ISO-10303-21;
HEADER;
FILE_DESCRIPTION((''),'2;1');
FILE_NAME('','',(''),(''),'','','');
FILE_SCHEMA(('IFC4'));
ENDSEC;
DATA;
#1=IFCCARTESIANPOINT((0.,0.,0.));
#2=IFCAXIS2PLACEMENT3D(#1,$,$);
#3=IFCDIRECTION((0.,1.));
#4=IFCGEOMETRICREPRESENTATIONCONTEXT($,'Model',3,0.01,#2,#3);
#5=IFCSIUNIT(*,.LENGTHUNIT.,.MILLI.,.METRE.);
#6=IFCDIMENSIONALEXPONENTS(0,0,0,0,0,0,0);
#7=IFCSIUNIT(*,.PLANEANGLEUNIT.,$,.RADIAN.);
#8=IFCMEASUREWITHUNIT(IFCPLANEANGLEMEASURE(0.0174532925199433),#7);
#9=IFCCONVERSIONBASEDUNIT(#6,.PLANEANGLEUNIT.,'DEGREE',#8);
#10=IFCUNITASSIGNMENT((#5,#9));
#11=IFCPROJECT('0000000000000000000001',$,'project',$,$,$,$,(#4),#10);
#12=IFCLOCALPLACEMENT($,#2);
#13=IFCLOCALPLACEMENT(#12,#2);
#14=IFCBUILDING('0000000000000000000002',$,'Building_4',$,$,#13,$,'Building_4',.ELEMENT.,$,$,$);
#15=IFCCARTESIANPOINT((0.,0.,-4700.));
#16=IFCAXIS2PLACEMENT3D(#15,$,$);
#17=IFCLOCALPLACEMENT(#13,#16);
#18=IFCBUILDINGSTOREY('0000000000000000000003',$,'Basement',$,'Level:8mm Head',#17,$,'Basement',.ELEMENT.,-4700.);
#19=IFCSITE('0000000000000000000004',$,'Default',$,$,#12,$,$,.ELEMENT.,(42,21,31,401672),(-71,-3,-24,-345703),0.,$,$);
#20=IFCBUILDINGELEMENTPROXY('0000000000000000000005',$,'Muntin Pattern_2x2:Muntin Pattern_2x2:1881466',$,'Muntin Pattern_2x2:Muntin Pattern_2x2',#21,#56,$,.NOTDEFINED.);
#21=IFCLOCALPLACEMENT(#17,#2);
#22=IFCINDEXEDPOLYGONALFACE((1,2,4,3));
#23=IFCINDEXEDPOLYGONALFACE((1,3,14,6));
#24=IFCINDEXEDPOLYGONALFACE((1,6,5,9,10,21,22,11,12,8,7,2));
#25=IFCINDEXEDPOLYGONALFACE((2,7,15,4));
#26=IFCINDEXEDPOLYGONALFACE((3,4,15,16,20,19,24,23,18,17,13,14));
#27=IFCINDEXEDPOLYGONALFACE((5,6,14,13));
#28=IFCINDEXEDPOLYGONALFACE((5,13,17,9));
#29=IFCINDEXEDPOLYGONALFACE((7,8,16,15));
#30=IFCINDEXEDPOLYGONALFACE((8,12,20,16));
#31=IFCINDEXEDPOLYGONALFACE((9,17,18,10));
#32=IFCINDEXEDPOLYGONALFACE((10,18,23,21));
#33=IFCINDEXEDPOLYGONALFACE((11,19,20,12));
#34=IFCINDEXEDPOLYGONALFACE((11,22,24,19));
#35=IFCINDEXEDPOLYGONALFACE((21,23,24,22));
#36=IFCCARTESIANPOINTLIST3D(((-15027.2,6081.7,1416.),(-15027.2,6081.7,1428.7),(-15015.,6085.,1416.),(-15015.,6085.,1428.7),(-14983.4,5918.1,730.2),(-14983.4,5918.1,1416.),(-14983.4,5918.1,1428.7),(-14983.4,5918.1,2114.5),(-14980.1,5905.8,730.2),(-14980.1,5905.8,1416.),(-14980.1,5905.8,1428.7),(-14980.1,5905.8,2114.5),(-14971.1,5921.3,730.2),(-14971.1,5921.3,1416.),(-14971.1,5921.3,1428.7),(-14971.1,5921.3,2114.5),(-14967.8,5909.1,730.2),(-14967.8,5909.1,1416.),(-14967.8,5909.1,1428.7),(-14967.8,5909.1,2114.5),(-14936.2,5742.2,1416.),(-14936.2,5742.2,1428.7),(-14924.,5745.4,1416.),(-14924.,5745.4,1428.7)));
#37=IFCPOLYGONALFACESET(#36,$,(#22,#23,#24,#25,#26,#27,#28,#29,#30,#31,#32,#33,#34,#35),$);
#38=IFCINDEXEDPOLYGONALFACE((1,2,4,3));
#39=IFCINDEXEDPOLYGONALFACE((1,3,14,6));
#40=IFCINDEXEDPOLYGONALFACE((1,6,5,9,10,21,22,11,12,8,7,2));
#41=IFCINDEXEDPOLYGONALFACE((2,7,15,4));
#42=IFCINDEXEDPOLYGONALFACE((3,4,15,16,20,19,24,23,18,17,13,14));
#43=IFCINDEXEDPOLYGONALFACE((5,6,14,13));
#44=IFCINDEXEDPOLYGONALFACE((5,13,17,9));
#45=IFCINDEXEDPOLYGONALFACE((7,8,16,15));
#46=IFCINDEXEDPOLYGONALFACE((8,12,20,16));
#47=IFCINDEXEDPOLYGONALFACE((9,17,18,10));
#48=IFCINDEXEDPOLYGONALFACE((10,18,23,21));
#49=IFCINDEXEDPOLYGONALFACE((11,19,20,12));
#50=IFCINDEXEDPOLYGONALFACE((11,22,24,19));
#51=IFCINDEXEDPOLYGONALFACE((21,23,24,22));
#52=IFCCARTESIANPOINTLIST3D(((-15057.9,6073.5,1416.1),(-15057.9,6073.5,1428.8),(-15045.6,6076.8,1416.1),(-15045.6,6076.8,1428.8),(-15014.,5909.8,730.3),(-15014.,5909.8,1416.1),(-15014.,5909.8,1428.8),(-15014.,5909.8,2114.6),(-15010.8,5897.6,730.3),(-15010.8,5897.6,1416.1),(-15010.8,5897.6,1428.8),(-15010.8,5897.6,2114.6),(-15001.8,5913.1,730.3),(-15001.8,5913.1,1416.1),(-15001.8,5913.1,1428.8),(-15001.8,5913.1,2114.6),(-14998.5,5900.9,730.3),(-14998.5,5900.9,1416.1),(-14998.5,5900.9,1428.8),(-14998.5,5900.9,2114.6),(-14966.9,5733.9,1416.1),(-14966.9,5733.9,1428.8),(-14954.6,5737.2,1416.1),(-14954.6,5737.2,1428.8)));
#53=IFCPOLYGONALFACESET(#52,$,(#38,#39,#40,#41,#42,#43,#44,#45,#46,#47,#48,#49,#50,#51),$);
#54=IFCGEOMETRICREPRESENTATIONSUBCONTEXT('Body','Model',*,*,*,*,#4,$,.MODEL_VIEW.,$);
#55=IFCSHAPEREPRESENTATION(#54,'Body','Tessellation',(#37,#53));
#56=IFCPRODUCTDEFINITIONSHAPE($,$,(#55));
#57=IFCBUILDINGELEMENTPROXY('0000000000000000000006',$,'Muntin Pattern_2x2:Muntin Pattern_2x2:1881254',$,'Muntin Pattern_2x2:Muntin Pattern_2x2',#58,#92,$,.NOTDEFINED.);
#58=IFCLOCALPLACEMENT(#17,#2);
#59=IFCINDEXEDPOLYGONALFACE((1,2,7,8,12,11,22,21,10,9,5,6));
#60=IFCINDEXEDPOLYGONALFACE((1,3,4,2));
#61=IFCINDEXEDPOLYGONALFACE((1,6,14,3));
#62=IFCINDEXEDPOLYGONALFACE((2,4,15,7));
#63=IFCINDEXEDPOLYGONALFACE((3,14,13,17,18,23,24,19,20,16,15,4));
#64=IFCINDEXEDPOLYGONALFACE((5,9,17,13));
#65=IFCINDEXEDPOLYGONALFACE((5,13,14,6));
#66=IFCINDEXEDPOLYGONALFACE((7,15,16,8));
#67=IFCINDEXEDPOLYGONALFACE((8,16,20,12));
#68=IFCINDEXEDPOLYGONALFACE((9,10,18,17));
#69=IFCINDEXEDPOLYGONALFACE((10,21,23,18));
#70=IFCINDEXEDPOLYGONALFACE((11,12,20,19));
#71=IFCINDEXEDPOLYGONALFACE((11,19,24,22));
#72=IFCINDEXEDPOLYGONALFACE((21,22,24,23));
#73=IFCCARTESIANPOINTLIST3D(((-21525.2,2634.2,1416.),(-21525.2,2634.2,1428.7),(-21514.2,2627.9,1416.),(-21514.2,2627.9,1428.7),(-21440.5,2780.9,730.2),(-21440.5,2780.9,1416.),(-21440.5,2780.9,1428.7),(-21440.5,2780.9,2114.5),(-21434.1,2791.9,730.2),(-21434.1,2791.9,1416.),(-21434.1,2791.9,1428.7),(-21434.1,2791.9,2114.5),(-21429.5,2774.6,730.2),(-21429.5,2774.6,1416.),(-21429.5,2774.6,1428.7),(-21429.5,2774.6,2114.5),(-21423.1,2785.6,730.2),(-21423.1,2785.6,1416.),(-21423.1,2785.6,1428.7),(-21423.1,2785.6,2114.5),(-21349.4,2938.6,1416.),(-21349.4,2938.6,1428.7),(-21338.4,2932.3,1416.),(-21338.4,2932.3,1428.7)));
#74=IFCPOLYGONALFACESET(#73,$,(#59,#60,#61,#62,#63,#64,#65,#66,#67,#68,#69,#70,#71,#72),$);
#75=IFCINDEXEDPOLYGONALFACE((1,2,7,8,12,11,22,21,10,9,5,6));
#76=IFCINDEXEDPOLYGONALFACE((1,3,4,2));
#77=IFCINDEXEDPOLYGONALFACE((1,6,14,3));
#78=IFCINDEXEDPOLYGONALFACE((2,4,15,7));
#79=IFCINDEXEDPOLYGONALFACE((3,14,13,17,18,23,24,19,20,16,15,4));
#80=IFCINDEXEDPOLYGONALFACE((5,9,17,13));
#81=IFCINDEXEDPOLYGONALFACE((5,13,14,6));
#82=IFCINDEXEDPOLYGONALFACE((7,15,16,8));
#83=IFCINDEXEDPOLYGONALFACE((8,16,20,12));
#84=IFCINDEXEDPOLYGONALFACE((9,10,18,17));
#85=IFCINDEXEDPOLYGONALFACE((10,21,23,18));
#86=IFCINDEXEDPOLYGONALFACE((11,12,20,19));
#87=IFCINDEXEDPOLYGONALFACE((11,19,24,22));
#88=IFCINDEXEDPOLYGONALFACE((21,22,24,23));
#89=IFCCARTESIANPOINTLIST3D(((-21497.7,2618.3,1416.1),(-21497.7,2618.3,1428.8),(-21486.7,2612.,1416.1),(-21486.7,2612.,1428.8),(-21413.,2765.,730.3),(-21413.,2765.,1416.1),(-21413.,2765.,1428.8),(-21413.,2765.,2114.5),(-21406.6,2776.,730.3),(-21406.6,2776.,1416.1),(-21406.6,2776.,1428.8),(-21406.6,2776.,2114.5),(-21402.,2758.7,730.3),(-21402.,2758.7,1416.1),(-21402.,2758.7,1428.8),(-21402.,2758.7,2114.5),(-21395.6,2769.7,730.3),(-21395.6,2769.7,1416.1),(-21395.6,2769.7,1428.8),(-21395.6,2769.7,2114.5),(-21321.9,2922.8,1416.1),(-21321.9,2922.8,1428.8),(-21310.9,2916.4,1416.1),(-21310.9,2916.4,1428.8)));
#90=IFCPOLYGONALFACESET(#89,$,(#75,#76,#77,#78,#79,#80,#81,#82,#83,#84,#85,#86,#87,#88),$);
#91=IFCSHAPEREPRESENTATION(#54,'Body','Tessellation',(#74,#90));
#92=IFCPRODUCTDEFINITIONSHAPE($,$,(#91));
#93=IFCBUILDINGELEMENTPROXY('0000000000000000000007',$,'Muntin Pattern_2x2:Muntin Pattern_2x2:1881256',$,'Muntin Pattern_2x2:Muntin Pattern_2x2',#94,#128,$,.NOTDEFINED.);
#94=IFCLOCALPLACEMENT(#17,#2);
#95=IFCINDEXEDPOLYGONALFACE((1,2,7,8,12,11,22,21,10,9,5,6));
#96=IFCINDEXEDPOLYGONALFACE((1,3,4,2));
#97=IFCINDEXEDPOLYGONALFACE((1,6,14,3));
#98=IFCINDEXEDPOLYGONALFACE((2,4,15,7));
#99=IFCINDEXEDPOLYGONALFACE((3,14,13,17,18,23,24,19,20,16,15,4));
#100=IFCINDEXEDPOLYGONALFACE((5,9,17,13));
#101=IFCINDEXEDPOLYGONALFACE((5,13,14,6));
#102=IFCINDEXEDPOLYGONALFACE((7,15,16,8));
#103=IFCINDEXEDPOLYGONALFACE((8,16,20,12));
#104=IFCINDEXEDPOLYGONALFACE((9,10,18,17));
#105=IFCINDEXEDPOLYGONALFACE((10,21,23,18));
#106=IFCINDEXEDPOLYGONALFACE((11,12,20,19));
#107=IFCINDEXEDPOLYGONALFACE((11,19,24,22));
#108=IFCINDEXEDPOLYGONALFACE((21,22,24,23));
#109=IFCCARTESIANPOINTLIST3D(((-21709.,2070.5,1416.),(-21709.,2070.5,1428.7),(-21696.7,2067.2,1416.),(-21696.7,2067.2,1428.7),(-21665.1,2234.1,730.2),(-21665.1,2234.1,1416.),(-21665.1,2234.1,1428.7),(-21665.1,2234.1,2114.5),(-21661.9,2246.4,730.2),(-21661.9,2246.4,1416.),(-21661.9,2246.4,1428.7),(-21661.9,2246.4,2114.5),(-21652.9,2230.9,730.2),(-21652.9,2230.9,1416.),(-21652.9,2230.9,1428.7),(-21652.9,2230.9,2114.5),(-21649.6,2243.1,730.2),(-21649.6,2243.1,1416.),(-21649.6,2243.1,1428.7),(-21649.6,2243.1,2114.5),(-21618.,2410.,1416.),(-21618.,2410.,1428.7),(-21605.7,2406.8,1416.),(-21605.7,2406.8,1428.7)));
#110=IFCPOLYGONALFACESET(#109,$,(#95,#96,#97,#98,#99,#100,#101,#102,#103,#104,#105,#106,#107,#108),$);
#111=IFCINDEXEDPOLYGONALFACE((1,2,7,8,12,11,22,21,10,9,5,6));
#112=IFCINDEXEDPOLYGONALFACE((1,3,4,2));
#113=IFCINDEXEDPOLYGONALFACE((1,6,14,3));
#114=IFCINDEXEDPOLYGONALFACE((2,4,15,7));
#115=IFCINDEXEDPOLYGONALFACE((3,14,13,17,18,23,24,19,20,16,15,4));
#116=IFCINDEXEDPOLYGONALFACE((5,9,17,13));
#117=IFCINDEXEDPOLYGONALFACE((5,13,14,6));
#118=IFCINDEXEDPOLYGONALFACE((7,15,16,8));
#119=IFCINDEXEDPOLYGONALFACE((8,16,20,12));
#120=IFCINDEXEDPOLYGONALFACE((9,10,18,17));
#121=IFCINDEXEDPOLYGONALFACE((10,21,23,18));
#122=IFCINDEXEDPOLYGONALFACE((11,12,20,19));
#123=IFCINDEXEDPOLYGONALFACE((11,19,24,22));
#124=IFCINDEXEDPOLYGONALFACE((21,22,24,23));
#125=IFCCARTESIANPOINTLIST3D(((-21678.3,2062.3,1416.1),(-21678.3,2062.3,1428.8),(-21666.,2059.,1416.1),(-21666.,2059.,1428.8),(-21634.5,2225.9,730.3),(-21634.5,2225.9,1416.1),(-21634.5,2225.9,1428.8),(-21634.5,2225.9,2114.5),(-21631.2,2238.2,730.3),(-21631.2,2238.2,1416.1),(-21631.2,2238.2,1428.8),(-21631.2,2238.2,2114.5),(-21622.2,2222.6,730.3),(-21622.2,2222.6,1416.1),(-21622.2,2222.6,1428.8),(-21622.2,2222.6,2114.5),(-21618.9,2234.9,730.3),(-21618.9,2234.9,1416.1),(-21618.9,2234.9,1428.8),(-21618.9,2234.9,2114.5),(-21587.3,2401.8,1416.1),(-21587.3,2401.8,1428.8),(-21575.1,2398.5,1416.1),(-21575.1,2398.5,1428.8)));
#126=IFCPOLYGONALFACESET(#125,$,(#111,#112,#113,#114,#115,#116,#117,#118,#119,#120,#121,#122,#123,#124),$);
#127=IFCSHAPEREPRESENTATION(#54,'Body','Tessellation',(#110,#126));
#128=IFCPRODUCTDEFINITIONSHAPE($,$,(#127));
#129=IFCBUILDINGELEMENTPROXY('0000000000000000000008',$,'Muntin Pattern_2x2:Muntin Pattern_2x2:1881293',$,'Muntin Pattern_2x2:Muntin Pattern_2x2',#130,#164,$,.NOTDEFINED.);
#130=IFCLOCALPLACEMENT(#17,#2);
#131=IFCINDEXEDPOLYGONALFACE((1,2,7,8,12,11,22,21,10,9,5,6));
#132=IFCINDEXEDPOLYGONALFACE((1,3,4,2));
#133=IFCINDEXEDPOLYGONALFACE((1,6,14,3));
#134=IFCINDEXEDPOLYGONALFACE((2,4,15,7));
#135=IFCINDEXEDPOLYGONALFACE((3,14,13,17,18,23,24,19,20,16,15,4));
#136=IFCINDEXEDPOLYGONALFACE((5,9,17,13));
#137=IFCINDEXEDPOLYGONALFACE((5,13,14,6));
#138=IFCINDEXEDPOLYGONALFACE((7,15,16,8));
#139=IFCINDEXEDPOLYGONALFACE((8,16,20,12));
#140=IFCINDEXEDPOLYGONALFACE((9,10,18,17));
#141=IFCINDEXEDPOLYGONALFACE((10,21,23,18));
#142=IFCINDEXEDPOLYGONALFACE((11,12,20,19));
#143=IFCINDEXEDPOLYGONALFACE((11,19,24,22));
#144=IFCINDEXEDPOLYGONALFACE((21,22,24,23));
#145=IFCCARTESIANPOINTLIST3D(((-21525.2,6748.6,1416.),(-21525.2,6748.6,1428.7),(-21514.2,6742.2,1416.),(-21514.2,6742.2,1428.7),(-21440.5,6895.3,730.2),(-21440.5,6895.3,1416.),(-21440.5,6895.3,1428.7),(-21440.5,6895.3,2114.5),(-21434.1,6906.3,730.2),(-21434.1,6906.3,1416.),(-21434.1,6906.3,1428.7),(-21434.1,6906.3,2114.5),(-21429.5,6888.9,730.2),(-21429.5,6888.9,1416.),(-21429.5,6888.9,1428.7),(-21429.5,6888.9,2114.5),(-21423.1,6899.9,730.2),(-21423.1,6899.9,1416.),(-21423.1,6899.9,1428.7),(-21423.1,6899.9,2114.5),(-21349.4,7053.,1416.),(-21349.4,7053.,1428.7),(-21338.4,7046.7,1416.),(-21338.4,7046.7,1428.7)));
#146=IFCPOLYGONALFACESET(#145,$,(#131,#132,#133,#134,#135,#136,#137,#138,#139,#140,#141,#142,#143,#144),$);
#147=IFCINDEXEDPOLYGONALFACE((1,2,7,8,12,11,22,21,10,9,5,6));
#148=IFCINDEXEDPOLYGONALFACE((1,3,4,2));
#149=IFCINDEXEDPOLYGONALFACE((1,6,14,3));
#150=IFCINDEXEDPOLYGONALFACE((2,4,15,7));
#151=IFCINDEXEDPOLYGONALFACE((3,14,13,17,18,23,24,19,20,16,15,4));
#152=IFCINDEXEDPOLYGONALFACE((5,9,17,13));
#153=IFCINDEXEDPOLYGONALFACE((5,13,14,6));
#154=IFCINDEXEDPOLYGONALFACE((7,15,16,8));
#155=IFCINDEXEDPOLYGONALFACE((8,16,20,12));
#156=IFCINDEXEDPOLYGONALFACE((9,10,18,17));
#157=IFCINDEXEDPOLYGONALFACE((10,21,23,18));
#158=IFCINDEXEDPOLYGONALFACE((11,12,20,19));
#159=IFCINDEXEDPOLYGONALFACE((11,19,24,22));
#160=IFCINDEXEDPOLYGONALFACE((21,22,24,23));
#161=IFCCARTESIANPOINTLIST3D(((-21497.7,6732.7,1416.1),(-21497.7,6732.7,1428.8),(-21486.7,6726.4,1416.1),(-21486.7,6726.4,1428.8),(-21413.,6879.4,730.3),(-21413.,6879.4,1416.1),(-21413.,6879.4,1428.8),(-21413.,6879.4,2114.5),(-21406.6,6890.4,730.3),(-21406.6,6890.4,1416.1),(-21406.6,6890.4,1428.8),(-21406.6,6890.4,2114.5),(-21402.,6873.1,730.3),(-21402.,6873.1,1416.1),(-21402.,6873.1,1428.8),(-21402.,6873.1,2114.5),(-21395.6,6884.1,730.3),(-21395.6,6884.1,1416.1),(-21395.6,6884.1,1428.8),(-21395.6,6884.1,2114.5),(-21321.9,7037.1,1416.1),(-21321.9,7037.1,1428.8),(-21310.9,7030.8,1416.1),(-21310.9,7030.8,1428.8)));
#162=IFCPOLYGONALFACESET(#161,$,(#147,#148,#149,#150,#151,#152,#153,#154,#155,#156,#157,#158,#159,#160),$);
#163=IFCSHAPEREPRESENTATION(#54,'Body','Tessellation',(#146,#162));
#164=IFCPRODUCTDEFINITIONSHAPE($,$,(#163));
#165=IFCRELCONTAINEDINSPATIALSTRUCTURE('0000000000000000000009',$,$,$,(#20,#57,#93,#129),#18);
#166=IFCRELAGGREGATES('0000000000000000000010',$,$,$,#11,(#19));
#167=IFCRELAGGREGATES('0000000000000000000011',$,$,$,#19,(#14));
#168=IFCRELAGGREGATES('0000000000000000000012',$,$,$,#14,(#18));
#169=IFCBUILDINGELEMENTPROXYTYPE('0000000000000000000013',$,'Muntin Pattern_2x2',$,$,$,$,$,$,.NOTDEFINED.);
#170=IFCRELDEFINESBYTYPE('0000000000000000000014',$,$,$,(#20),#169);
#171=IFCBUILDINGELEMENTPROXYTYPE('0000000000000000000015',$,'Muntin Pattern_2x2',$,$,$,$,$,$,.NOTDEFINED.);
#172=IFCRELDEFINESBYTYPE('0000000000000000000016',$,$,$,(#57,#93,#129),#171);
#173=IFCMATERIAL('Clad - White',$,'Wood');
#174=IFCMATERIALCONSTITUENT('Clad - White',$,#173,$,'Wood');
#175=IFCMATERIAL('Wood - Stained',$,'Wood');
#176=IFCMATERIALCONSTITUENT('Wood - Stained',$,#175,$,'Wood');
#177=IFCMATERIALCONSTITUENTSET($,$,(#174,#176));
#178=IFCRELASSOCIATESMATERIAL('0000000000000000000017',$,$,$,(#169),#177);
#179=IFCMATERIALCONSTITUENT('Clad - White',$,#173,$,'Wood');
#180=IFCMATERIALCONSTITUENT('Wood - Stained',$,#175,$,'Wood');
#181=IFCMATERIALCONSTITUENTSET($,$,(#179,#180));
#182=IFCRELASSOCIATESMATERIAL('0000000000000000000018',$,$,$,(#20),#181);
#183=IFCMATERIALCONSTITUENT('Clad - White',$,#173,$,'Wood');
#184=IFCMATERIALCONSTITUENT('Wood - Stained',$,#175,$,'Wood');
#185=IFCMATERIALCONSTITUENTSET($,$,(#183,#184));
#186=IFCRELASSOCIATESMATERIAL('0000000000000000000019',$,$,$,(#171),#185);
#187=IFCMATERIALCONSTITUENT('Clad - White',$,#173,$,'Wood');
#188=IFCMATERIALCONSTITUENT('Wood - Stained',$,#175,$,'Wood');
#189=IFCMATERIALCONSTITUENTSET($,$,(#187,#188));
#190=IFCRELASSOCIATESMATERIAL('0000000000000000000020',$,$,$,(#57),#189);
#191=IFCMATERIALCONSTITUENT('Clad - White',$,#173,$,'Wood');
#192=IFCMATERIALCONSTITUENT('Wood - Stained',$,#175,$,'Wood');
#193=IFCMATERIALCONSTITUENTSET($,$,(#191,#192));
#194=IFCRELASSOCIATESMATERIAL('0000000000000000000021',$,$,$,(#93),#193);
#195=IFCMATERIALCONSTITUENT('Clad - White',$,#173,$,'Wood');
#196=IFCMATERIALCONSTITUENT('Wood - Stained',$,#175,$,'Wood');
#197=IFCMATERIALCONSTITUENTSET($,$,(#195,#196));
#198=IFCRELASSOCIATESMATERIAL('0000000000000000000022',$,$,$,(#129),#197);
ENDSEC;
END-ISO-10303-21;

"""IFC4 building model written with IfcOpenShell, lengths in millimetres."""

from ifc_helpers import new_model, entity, si_unit, converted_unit, direction, frame, origin, place, context, subcontext, project, spatial, indexed_curve, outline, extrude, source, transform, mapped, material, constituent, constituent_set, type_object, type_shapes, element, save


model = new_model("IFC4")

# Units and contexts
model_context = context("Model", 3, precision=0.01, world=origin(), true_north=direction((0.0, 1.0)))
body_context = subcontext(model_context, "Body", "Model", "MODEL_VIEW")
ifc_project = project(units=[si_unit("LENGTHUNIT", "METRE", prefix="MILLI"), converted_unit("PLANEANGLEUNIT", "DEGREE", entity("IfcPlaneAngleMeasure", 0.0174532925199433), si_unit("PLANEANGLEUNIT", "RADIAN"), dimensions=[0, 0, 0, 0, 0, 0, 0])], contexts=[model_context])

# Site, building, storey
site_placement = place(None, origin())
site = spatial("IfcSite", under=ifc_project, at=site_placement, Name="Default", CompositionType="ELEMENT", RefLatitude=(42, 21, 31, 401672), RefLongitude=(-71, -3, -24, -345703), RefElevation=0.0)
building_placement = place(site_placement, origin())
building = spatial("IfcBuilding", under=site, at=building_placement, Name="Building_4", LongName="Building_4", CompositionType="ELEMENT")
storey_placement = place(building_placement, frame((0.0, 0.0, -4700.0)))
storey = spatial("IfcBuildingStorey", under=building, at=storey_placement, Name="Basement", ObjectType="Level:8mm Head", LongName="Basement", CompositionType="ELEMENT", Elevation=-4700.0)

# Building element proxies
ifc_material_1 = material(Name="Clad - White", Category="Wood")
ifc_material_2 = material(Name="Wood - Stained", Category="Wood")
ifc_constituent_1 = constituent(ifc_material_1, Name="Clad - White", Category="Wood")
ifc_constituent_2 = constituent(ifc_material_2, Name="Wood - Stained", Category="Wood")
ifc_constituent_set_1 = constituent_set(constituents=[ifc_constituent_1, ifc_constituent_2])
building_element_proxy_type_1 = type_object("IfcBuildingElementProxyType", Name="Muntin Pattern_2x2", PredefinedType="NOTDEFINED", material=ifc_constituent_set_1)
shared_shape_1 = source(origin(), body_context, "Body", "SweptSolid", [
    extrude(outline(indexed_curve([(6.4, -6.4), (692.1, -6.4), (692.1, 6.3), (6.4, 6.3), (6.4, 175.8), (-6.3, 175.8), (-6.3, 6.3), (-692.2, 6.3), (-692.2, -6.4), (-6.3, -6.4), (-6.3, -175.8), (6.4, -175.8), (6.4, -6.4)], self_intersect=False)), frame((0.0, 9.5, 692.1), z_axis=(0.0, 1.0, 0.0), x_axis=(0.0, 0.0, 1.0)), (0.0, 0.0, 1.0), 12.7),
    extrude(outline(indexed_curve([(6.4, -6.4), (692.1, -6.4), (692.1, 6.3), (6.4, 6.3), (6.4, 175.8), (-6.3, 175.8), (-6.3, 6.3), (-692.2, 6.3), (-692.2, -6.4), (-6.3, -6.4), (-6.3, -175.8), (6.4, -175.8), (6.4, -6.4)], self_intersect=False)), frame((0.0, -22.2, 692.2), z_axis=(0.0, 1.0, 0.0), x_axis=(0.0, 0.0, 1.0)), (0.0, 0.0, 1.0), 12.7),
])
type_shapes(building_element_proxy_type_1, [shared_shape_1])
ifc_constituent_3 = constituent(ifc_material_1, Name="Clad - White", Category="Wood")
ifc_constituent_4 = constituent(ifc_material_2, Name="Wood - Stained", Category="Wood")
ifc_constituent_set_2 = constituent_set(constituents=[ifc_constituent_3, ifc_constituent_4])
proxy_1_placement = place(storey_placement, frame((-14990.9, 5909.5, 730.3), z_axis=(0.0, 0.0, 1.0), x_axis=(0.258819, -0.965926, 0.0)))
element("IfcBuildingElementProxy", 1, at=proxy_1_placement, inside=storey, type_object=building_element_proxy_type_1, material=ifc_constituent_set_2, Name="Muntin Pattern_2x2:Muntin Pattern_2x2:1881466", ObjectType="Muntin Pattern_2x2:Muntin Pattern_2x2", PredefinedType="NOTDEFINED", context=body_context, shape_type="MappedRepresentation", body=[
    mapped(shared_shape_1, transform((0.0, 0.0, 0.0), scale=1.0)),
])
ifc_constituent_5 = constituent(ifc_material_1, Name="Clad - White", Category="Wood")
ifc_constituent_6 = constituent(ifc_material_2, Name="Wood - Stained", Category="Wood")
ifc_constituent_set_3 = constituent_set(constituents=[ifc_constituent_5, ifc_constituent_6])
ifc_constituent_7 = constituent(ifc_material_1, Name="Clad - White", Category="Wood")
ifc_constituent_8 = constituent(ifc_material_2, Name="Wood - Stained", Category="Wood")
ifc_constituent_set_4 = constituent_set(constituents=[ifc_constituent_7, ifc_constituent_8])
building_element_proxy_type_2 = type_object("IfcBuildingElementProxyType", Name="Muntin Pattern_2x2", PredefinedType="NOTDEFINED", material=ifc_constituent_set_4)
shared_shape_2 = source(origin(), body_context, "Body", "SweptSolid", [
    extrude(outline(indexed_curve([(6.4, -6.4), (692.1, -6.4), (692.1, 6.3), (6.4, 6.3), (6.4, 175.8), (-6.3, 175.8), (-6.3, 6.3), (-692.2, 6.3), (-692.2, -6.4), (-6.3, -6.4), (-6.3, -175.8), (6.4, -175.8), (6.4, -6.4)], self_intersect=False)), frame((0.0, -22.2, 692.1), z_axis=(0.0, 1.0, 0.0), x_axis=(0.0, 0.0, 1.0)), (0.0, 0.0, 1.0), 12.7),
    extrude(outline(indexed_curve([(6.4, -6.4), (692.1, -6.4), (692.1, 6.3), (6.4, 6.3), (6.4, 175.8), (-6.3, 175.8), (-6.3, 6.3), (-692.1, 6.3), (-692.1, -6.4), (-6.3, -6.4), (-6.3, -175.8), (6.4, -175.8), (6.4, -6.4)], self_intersect=False)), frame((0.0, 9.5, 692.1), z_axis=(0.0, 1.0, 0.0), x_axis=(0.0, 0.0, 1.0)), (0.0, 0.0, 1.0), 12.7),
])
type_shapes(building_element_proxy_type_2, [shared_shape_2])
proxy_2_placement = place(storey_placement, frame((-21418.0, 2775.3, 730.3), z_axis=(0.0, 0.0, 1.0), x_axis=(-0.5, -0.866025, 0.0)))
element("IfcBuildingElementProxy", 2, at=proxy_2_placement, inside=storey, type_object=building_element_proxy_type_2, material=ifc_constituent_set_3, Name="Muntin Pattern_2x2:Muntin Pattern_2x2:1881254", ObjectType="Muntin Pattern_2x2:Muntin Pattern_2x2", PredefinedType="NOTDEFINED", context=body_context, shape_type="MappedRepresentation", body=[
    mapped(shared_shape_2, transform((0.0, 0.0, 0.0), scale=1.0)),
])
ifc_constituent_9 = constituent(ifc_material_1, Name="Clad - White", Category="Wood")
ifc_constituent_10 = constituent(ifc_material_2, Name="Wood - Stained", Category="Wood")
ifc_constituent_set_5 = constituent_set(constituents=[ifc_constituent_9, ifc_constituent_10])
proxy_3_placement = place(storey_placement, frame((-21642.0, 2234.5, 730.3), z_axis=(0.0, 0.0, 1.0), x_axis=(-0.258819, -0.965926, 0.0)))
element("IfcBuildingElementProxy", 3, at=proxy_3_placement, inside=storey, type_object=building_element_proxy_type_2, material=ifc_constituent_set_5, Name="Muntin Pattern_2x2:Muntin Pattern_2x2:1881256", ObjectType="Muntin Pattern_2x2:Muntin Pattern_2x2", PredefinedType="NOTDEFINED", context=body_context, shape_type="MappedRepresentation", body=[
    mapped(shared_shape_2, transform((0.0, 0.0, 0.0), scale=1.0)),
])
ifc_constituent_11 = constituent(ifc_material_1, Name="Clad - White", Category="Wood")
ifc_constituent_12 = constituent(ifc_material_2, Name="Wood - Stained", Category="Wood")
ifc_constituent_set_6 = constituent_set(constituents=[ifc_constituent_11, ifc_constituent_12])
proxy_4_placement = place(storey_placement, frame((-21418.0, 6889.7, 730.3), z_axis=(0.0, 0.0, 1.0), x_axis=(-0.5, -0.866025, 0.0)))
element("IfcBuildingElementProxy", 4, at=proxy_4_placement, inside=storey, type_object=building_element_proxy_type_2, material=ifc_constituent_set_6, Name="Muntin Pattern_2x2:Muntin Pattern_2x2:1881293", ObjectType="Muntin Pattern_2x2:Muntin Pattern_2x2", PredefinedType="NOTDEFINED", context=body_context, shape_type="MappedRepresentation", body=[
    mapped(shared_shape_2, transform((0.0, 0.0, 0.0), scale=1.0)),
])

save(model, "model.ifc")
